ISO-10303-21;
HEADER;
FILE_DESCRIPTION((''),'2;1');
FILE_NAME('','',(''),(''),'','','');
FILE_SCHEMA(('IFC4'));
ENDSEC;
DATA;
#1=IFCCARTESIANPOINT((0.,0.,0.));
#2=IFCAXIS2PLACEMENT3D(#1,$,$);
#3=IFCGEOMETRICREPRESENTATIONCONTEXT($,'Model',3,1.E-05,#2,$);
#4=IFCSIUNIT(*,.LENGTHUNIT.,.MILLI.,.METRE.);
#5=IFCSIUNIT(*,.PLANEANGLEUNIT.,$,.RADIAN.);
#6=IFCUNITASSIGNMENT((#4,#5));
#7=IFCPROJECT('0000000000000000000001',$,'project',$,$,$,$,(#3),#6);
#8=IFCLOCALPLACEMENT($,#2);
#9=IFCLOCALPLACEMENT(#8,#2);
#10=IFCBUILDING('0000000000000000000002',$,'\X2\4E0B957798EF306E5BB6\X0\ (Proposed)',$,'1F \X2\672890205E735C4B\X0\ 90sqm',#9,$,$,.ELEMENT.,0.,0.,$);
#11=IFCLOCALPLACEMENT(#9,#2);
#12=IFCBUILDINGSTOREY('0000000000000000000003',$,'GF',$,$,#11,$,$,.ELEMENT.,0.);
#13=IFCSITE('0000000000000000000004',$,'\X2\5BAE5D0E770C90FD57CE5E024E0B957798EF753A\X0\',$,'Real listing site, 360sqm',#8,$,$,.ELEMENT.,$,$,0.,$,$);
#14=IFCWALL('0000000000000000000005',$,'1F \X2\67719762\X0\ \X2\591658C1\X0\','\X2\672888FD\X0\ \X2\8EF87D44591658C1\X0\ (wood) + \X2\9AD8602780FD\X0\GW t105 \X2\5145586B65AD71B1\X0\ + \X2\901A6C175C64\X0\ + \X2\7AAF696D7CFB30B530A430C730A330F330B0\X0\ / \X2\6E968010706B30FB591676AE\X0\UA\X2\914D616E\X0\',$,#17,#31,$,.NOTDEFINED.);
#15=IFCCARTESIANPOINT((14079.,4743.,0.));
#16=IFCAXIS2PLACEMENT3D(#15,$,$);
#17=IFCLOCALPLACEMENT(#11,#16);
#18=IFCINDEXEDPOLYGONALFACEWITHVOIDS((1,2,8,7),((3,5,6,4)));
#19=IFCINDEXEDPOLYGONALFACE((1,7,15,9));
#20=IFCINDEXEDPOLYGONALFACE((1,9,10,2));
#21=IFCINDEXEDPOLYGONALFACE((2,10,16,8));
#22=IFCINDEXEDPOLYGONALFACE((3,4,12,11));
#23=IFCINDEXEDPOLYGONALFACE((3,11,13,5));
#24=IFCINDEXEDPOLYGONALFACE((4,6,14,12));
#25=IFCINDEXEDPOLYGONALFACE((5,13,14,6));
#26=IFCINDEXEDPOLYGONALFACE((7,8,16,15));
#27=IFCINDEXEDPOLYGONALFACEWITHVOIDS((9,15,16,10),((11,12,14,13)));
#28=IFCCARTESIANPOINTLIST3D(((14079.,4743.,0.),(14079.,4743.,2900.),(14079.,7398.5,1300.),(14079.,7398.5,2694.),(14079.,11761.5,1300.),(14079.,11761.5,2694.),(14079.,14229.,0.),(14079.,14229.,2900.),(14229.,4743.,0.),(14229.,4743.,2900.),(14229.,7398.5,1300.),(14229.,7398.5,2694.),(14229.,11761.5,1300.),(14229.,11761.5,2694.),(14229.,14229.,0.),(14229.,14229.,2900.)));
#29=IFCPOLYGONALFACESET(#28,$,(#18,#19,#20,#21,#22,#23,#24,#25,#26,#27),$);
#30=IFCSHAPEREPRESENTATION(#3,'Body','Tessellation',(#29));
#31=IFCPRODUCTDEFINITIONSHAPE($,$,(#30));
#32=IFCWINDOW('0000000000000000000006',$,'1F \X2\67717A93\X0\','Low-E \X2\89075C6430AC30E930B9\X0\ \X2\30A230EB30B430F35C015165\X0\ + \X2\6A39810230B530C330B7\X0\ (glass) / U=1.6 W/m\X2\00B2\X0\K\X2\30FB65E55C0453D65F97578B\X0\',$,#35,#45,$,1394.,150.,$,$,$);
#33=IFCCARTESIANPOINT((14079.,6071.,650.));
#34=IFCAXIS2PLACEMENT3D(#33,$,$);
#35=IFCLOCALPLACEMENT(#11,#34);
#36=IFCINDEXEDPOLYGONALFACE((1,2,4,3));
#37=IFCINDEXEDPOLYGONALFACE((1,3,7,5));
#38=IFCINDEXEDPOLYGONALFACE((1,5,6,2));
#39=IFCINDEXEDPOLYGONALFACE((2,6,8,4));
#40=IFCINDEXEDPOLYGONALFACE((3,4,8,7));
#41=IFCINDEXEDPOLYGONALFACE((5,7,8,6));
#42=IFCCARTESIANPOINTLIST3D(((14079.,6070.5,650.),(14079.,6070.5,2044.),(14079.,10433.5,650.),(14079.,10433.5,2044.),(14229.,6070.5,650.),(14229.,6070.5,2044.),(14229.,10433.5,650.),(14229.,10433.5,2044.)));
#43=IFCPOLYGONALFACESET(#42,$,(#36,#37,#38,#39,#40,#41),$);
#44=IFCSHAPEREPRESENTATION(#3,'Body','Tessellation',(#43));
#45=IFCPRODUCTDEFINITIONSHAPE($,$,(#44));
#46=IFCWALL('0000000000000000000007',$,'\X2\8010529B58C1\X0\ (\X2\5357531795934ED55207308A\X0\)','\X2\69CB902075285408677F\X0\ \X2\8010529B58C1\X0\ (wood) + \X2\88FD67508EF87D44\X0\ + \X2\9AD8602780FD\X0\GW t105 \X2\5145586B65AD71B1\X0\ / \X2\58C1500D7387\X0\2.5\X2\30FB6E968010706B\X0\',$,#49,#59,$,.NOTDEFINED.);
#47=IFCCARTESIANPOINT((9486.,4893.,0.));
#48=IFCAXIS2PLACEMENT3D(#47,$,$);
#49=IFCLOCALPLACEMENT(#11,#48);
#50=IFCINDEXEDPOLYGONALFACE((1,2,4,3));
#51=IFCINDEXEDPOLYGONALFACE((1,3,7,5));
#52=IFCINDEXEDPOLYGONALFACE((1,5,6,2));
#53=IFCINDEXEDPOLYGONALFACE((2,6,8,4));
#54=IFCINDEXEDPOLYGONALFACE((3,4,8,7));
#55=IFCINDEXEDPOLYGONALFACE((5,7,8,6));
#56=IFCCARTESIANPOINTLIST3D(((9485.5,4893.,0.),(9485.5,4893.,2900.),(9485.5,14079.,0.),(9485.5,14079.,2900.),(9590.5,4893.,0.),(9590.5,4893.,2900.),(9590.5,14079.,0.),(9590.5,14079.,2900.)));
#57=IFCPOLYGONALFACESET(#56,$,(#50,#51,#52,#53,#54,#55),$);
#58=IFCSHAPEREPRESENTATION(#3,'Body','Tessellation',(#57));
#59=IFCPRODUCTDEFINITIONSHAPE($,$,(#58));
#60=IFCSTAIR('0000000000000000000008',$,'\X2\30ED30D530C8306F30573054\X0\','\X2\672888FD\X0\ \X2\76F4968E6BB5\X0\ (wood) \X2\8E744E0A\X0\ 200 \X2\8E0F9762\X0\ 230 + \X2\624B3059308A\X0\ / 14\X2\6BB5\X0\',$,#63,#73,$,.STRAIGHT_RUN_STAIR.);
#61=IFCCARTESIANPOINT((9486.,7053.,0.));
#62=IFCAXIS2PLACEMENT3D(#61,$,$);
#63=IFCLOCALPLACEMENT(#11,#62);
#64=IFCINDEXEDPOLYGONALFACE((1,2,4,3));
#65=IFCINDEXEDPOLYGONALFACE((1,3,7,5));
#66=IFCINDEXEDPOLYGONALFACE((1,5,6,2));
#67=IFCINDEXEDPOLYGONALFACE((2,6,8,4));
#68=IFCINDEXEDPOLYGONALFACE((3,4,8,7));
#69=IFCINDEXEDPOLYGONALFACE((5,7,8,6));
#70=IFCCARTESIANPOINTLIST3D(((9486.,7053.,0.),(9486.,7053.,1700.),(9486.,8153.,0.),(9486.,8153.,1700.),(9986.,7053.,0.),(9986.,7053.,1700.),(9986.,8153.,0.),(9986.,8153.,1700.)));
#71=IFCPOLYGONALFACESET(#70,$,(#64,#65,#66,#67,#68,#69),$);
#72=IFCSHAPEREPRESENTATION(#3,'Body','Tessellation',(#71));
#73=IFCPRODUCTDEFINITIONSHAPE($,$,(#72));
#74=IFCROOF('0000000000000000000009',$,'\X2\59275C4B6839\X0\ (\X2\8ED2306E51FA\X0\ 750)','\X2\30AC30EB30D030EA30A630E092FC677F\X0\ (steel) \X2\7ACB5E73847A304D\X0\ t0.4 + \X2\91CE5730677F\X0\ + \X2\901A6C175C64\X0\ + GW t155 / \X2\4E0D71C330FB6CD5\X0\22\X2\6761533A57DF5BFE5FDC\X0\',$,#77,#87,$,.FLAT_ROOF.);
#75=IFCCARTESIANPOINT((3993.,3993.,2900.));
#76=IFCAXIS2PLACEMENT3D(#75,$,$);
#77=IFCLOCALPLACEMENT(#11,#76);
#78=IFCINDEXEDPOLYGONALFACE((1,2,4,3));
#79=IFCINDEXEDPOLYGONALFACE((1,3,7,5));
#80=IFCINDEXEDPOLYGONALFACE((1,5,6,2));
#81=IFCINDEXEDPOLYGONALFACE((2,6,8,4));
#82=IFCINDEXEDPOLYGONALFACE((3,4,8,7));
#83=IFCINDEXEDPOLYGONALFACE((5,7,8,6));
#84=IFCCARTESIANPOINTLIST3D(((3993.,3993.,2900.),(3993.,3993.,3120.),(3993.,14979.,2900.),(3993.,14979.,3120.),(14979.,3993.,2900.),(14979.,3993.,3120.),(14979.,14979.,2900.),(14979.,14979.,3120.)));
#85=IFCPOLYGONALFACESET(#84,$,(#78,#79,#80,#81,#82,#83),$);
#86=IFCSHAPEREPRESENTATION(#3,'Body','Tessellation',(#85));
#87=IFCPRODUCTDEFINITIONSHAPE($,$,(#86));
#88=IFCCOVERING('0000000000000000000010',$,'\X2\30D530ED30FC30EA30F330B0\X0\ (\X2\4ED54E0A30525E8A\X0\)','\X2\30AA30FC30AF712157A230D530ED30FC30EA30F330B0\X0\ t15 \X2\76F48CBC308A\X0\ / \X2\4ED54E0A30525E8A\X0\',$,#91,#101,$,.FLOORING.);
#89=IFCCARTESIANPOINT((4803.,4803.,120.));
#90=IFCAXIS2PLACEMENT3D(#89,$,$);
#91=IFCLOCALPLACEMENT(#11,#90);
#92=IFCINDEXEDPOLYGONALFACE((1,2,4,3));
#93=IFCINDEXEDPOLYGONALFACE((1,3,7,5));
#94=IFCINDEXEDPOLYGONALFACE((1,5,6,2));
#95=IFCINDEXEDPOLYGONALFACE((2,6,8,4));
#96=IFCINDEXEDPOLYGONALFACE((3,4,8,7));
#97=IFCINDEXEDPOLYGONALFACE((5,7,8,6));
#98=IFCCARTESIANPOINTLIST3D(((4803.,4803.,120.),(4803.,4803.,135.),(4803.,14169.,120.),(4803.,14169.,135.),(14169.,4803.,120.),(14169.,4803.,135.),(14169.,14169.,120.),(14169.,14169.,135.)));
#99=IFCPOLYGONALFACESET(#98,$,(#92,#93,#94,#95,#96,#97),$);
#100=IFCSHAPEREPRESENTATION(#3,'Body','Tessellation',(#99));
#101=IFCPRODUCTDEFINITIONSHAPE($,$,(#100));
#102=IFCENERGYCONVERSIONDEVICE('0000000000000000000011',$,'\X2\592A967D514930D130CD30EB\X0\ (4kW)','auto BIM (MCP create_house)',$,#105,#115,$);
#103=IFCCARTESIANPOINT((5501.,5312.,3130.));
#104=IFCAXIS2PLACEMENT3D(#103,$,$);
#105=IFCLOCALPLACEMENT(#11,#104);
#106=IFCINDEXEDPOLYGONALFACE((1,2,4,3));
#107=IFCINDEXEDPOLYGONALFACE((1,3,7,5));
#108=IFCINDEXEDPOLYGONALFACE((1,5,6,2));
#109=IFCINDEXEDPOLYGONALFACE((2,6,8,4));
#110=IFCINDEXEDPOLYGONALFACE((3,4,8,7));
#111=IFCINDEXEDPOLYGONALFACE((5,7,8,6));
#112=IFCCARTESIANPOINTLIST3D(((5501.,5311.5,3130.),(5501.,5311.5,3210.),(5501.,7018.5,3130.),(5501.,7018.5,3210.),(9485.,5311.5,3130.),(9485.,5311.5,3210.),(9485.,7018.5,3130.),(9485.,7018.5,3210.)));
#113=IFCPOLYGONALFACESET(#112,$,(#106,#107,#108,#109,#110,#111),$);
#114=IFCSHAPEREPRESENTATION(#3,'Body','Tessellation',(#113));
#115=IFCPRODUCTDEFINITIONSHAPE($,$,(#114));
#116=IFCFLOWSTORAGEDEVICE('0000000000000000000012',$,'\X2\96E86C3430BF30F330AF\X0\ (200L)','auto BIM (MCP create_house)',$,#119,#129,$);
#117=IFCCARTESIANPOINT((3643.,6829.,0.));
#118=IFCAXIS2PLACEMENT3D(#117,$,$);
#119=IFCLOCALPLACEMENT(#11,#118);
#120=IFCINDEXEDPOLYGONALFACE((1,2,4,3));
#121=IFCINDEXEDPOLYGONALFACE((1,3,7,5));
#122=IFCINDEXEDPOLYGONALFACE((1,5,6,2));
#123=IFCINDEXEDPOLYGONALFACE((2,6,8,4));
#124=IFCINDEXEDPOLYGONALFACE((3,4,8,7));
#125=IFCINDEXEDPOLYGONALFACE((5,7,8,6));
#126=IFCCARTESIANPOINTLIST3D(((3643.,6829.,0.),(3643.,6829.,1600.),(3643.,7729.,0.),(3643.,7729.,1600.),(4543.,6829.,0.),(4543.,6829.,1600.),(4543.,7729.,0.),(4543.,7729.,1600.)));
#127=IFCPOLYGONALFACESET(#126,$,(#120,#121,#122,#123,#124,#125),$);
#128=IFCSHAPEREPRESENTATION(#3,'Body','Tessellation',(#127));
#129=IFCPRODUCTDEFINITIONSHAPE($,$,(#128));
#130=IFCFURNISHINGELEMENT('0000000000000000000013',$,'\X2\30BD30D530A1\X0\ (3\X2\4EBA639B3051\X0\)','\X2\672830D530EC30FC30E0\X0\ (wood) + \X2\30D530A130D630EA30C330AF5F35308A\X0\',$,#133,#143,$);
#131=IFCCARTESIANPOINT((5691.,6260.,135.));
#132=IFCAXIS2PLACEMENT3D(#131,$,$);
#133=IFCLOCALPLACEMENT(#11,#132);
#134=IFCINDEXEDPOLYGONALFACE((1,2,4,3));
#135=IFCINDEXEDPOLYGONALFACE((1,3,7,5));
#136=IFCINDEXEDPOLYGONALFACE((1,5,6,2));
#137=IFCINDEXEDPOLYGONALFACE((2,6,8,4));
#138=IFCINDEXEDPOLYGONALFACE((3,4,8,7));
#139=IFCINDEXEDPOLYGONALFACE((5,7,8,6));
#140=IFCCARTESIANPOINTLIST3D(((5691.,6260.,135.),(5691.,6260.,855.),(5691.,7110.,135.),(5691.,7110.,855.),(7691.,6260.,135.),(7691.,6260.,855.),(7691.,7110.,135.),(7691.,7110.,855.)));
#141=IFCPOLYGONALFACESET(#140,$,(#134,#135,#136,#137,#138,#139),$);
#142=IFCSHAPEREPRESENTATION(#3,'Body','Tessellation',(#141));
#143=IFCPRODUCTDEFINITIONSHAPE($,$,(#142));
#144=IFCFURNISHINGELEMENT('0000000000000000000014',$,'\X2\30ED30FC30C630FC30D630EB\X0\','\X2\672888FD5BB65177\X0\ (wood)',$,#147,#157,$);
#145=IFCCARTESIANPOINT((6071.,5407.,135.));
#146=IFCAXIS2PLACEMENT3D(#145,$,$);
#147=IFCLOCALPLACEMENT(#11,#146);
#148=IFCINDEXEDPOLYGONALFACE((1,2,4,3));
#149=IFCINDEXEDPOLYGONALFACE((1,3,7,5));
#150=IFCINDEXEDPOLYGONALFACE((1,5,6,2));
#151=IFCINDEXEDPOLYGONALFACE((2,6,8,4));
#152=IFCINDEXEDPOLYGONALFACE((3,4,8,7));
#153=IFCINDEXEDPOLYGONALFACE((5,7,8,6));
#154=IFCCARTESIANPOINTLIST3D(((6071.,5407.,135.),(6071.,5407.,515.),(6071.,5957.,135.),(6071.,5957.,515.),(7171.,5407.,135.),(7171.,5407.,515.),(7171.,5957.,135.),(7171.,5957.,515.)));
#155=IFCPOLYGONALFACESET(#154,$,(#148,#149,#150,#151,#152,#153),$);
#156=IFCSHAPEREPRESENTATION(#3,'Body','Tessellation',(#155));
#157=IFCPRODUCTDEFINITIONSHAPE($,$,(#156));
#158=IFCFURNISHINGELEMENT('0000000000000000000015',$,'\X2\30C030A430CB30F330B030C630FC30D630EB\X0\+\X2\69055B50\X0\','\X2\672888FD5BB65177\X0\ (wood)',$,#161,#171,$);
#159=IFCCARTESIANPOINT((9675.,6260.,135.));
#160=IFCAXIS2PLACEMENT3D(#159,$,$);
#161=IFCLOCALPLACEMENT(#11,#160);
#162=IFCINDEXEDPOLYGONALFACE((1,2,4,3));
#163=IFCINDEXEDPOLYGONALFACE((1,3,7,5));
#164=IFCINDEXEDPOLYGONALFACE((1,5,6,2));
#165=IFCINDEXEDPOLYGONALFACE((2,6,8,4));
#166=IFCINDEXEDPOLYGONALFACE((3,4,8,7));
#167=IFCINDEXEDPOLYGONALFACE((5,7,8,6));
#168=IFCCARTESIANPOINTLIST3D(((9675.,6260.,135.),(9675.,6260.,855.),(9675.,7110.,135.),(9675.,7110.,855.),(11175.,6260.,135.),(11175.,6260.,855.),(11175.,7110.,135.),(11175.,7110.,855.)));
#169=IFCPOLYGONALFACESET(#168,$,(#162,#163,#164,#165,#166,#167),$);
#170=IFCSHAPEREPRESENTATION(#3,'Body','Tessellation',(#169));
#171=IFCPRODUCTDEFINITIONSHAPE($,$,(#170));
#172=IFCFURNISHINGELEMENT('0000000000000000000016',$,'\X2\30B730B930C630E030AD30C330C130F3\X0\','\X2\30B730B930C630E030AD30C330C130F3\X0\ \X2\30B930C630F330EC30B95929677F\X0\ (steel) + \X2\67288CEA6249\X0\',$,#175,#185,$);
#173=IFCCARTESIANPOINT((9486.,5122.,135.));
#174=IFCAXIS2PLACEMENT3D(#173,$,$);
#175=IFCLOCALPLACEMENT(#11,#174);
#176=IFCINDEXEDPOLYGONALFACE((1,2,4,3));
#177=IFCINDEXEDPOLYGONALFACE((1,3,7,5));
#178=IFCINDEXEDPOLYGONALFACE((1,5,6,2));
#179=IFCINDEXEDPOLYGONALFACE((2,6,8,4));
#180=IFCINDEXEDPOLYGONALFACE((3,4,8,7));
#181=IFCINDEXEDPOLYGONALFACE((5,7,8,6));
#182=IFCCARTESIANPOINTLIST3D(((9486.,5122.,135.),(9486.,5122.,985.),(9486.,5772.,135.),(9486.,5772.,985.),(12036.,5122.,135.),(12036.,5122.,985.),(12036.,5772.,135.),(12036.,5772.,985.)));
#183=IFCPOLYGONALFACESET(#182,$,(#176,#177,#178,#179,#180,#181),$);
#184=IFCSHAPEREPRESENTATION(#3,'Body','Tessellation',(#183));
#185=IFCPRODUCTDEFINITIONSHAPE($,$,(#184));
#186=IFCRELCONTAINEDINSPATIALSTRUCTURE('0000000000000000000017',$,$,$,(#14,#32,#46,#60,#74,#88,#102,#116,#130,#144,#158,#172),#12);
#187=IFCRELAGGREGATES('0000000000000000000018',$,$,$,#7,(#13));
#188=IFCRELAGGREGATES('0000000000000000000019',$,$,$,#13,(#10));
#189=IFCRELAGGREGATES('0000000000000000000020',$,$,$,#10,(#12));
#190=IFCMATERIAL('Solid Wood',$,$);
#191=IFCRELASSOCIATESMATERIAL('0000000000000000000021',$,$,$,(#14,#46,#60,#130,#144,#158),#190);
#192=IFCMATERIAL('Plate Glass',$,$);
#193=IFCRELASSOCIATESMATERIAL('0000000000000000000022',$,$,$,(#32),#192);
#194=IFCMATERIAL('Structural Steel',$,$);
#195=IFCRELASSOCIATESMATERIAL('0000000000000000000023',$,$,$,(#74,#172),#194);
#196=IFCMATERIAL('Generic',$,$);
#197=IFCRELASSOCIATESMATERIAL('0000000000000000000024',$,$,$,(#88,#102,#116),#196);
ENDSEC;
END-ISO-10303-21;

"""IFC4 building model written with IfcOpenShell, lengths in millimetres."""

from ifc_helpers import new_model, si_unit, frame, frame_2d, origin, place, context, project, spatial, rectangle, extrude, material, element, fill, save


model = new_model("IFC4")

# Units and contexts
model_context = context("Model", 3, precision=1e-05, world=origin())
ifc_project = project(units=[si_unit("LENGTHUNIT", "METRE", prefix="MILLI"), si_unit("PLANEANGLEUNIT", "RADIAN")], contexts=[model_context])

# Site, building, storey
site_placement = place(None, origin())
site = spatial("IfcSite", under=ifc_project, at=site_placement, Name="宮崎県都城市下長飯町", ObjectType="Real listing site, 360sqm", CompositionType="ELEMENT", RefElevation=0.0)
building_placement = place(site_placement, origin())
building = spatial("IfcBuilding", under=site, at=building_placement, Name="下長飯の家 (Proposed)", ObjectType="1F 木造平屋 90sqm", CompositionType="ELEMENT", ElevationOfRefHeight=0.0, ElevationOfTerrain=0.0)
storey_placement = place(building_placement, origin())
storey = spatial("IfcBuildingStorey", under=building, at=storey_placement, Name="GF", CompositionType="ELEMENT", Elevation=0.0)

# Shared definitions
ifc_material_1 = material(Name="Solid Wood")

# Shared definitions
ifc_material_2 = material(Name="Plate Glass")

# Wall, opening, window
wall_1_placement = place(storey_placement, frame((14079.0, 4743.0, 0.0)))
wall_1 = element("IfcWall", 1, at=wall_1_placement, inside=storey, material=ifc_material_1, Name="1F 東面 外壁", Description="木製 軸組外壁 (wood) + 高性能GW t105 充填断熱 + 通気層 + 窯業系サイディング / 準耐火・外皮UA配慮", PredefinedType="NOTDEFINED", context=model_context, shape_type="SweptSolid", body=[
    extrude(rectangle(XDim=150.0, YDim=9486.0, at=frame_2d((75.0, 4743.0))), frame((14079.0, 4743.0, 0.0)), (0.0, 0.0, 1.0), 2900.0),
])
opening_1_placement = place(storey_placement, frame((14079.0, 6071.0, 650.0)))
opening_1 = element("IfcOpeningElement", 2, at=opening_1_placement, cuts=wall_1, PredefinedType="NOTDEFINED", context=model_context, shape_type="SweptSolid", body=[
    extrude(rectangle(XDim=150.0, YDim=4363.0, at=frame_2d((75.0, 2181.0))), frame((14079.0, 6071.0, 650.0)), (0.0, 0.0, 1.0), 1394.0),
])
window_1_placement = place(storey_placement, frame((14079.0, 6071.0, 650.0)))
window_1 = element("IfcWindow", 3, at=window_1_placement, inside=storey, material=ifc_material_2, Name="1F 東窓", Description="Low-E 複層ガラス アルゴン封入 + 樹脂サッシ (glass) / U=1.6 W/m²K・日射取得型", OverallHeight=1394.0, OverallWidth=150.0, context=model_context, shape_type="SweptSolid", body=[
    extrude(rectangle(XDim=150.0, YDim=4363.0, at=frame_2d((75.0, 2181.0))), frame((14079.0, 6071.0, 650.0)), (0.0, 0.0, 1.0), 1394.0),
])
fill(opening_1, window_1)

# Wall
wall_2_placement = place(storey_placement, frame((9486.0, 4893.0, 0.0)))
element("IfcWall", 4, at=wall_2_placement, inside=storey, material=ifc_material_1, Name="耐力壁 (南北間仕切り)", Description="構造用合板 耐力壁 (wood) + 製材軸組 + 高性能GW t105 充填断熱 / 壁倍率2.5・準耐火", PredefinedType="NOTDEFINED", context=model_context, shape_type="SweptSolid", body=[
    extrude(rectangle(XDim=105.0, YDim=9186.0, at=frame_2d((52.0, 4593.0))), frame((9486.0, 4893.0, 0.0)), (0.0, 0.0, 1.0), 2900.0),
])

# Stair
stair_placement = place(storey_placement, frame((9486.0, 7053.0, 0.0)))
element("IfcStair", 5, at=stair_placement, inside=storey, material=ifc_material_1, Name="ロフトはしご", Description="木製 直階段 (wood) 蹴上 200 踏面 230 + 手すり / 14段", PredefinedType="STRAIGHT_RUN_STAIR", context=model_context, shape_type="SweptSolid", body=[
    extrude(rectangle(XDim=500.0, YDim=1100.0, at=frame_2d((250.0, 550.0))), frame((9486.0, 7053.0, 0.0)), (0.0, 0.0, 1.0), 1700.0),
])

# Roof
ifc_material_3 = material(Name="Structural Steel")
roof_placement = place(storey_placement, frame((3993.0, 3993.0, 2900.0)))
element("IfcRoof", 6, at=roof_placement, inside=storey, material=ifc_material_3, Name="大屋根 (軒の出 750)", Description="ガルバリウム鋼板 (steel) 立平葺き t0.4 + 野地板 + 通気層 + GW t155 / 不燃・法22条区域対応", PredefinedType="FLAT_ROOF", context=model_context, shape_type="SweptSolid", body=[
    extrude(rectangle(XDim=10986.0, YDim=10986.0, at=frame_2d((5493.0, 5493.0))), frame((3993.0, 3993.0, 2900.0)), (0.0, 0.0, 1.0), 220.0),
])

# Covering
ifc_material_4 = material(Name="Generic")
covering_placement = place(storey_placement, frame((4803.0, 4803.0, 120.0)))
element("IfcCovering", 7, at=covering_placement, inside=storey, material=ifc_material_4, Name="フローリング (仕上げ床)", Description="オーク無垢フローリング t15 直貼り / 仕上げ床", PredefinedType="FLOORING", context=model_context, shape_type="SweptSolid", body=[
    extrude(rectangle(XDim=9366.0, YDim=9366.0, at=frame_2d((4683.0, 4683.0))), frame((4803.0, 4803.0, 120.0)), (0.0, 0.0, 1.0), 15.0),
])

# Energy conversion device
energy_conversion_device_placement = place(storey_placement, frame((5501.0, 5312.0, 3130.0)))
element("IfcEnergyConversionDevice", 8, at=energy_conversion_device_placement, inside=storey, material=ifc_material_4, Name="太陽光パネル (4kW)", Description="auto BIM (MCP create_house)", context=model_context, shape_type="SweptSolid", body=[
    extrude(rectangle(XDim=3984.0, YDim=1707.0, at=frame_2d((1992.0, 853.0))), frame((5501.0, 5312.0, 3130.0)), (0.0, 0.0, 1.0), 80.0),
])

# Flow storage device
flow_storage_device_placement = place(storey_placement, frame((3643.0, 6829.0, 0.0)))
element("IfcFlowStorageDevice", 9, at=flow_storage_device_placement, inside=storey, material=ifc_material_4, Name="雨水タンク (200L)", Description="auto BIM (MCP create_house)", context=model_context, shape_type="SweptSolid", body=[
    extrude(rectangle(XDim=900.0, YDim=900.0, at=frame_2d((450.0, 450.0))), frame((3643.0, 6829.0, 0.0)), (0.0, 0.0, 1.0), 1600.0),
])

# Furnishing elements
furnishing_1_placement = place(storey_placement, frame((5691.0, 6260.0, 135.0)))
element("IfcFurnishingElement", 10, at=furnishing_1_placement, inside=storey, material=ifc_material_1, Name="ソファ (3人掛け)", Description="木フレーム (wood) + ファブリック張り", context=model_context, shape_type="SweptSolid", body=[
    extrude(rectangle(XDim=2000.0, YDim=850.0, at=frame_2d((1000.0, 425.0))), frame((5691.0, 6260.0, 135.0)), (0.0, 0.0, 1.0), 720.0),
])
furnishing_2_placement = place(storey_placement, frame((6071.0, 5407.0, 135.0)))
element("IfcFurnishingElement", 11, at=furnishing_2_placement, inside=storey, material=ifc_material_1, Name="ローテーブル", Description="木製家具 (wood)", context=model_context, shape_type="SweptSolid", body=[
    extrude(rectangle(XDim=1100.0, YDim=550.0, at=frame_2d((550.0, 275.0))), frame((6071.0, 5407.0, 135.0)), (0.0, 0.0, 1.0), 380.0),
])
furnishing_3_placement = place(storey_placement, frame((9675.0, 6260.0, 135.0)))
element("IfcFurnishingElement", 12, at=furnishing_3_placement, inside=storey, material=ifc_material_1, Name="ダイニングテーブル+椅子", Description="木製家具 (wood)", context=model_context, shape_type="SweptSolid", body=[
    extrude(rectangle(XDim=1500.0, YDim=850.0, at=frame_2d((750.0, 425.0))), frame((9675.0, 6260.0, 135.0)), (0.0, 0.0, 1.0), 720.0),
])
furnishing_4_placement = place(storey_placement, frame((9486.0, 5122.0, 135.0)))
element("IfcFurnishingElement", 13, at=furnishing_4_placement, inside=storey, material=ifc_material_3, Name="システムキッチン", Description="システムキッチン ステンレス天板 (steel) + 木質扉", context=model_context, shape_type="SweptSolid", body=[
    extrude(rectangle(XDim=2550.0, YDim=650.0, at=frame_2d((1275.0, 325.0))), frame((9486.0, 5122.0, 135.0)), (0.0, 0.0, 1.0), 850.0),
])

save(model, "model.ifc")
